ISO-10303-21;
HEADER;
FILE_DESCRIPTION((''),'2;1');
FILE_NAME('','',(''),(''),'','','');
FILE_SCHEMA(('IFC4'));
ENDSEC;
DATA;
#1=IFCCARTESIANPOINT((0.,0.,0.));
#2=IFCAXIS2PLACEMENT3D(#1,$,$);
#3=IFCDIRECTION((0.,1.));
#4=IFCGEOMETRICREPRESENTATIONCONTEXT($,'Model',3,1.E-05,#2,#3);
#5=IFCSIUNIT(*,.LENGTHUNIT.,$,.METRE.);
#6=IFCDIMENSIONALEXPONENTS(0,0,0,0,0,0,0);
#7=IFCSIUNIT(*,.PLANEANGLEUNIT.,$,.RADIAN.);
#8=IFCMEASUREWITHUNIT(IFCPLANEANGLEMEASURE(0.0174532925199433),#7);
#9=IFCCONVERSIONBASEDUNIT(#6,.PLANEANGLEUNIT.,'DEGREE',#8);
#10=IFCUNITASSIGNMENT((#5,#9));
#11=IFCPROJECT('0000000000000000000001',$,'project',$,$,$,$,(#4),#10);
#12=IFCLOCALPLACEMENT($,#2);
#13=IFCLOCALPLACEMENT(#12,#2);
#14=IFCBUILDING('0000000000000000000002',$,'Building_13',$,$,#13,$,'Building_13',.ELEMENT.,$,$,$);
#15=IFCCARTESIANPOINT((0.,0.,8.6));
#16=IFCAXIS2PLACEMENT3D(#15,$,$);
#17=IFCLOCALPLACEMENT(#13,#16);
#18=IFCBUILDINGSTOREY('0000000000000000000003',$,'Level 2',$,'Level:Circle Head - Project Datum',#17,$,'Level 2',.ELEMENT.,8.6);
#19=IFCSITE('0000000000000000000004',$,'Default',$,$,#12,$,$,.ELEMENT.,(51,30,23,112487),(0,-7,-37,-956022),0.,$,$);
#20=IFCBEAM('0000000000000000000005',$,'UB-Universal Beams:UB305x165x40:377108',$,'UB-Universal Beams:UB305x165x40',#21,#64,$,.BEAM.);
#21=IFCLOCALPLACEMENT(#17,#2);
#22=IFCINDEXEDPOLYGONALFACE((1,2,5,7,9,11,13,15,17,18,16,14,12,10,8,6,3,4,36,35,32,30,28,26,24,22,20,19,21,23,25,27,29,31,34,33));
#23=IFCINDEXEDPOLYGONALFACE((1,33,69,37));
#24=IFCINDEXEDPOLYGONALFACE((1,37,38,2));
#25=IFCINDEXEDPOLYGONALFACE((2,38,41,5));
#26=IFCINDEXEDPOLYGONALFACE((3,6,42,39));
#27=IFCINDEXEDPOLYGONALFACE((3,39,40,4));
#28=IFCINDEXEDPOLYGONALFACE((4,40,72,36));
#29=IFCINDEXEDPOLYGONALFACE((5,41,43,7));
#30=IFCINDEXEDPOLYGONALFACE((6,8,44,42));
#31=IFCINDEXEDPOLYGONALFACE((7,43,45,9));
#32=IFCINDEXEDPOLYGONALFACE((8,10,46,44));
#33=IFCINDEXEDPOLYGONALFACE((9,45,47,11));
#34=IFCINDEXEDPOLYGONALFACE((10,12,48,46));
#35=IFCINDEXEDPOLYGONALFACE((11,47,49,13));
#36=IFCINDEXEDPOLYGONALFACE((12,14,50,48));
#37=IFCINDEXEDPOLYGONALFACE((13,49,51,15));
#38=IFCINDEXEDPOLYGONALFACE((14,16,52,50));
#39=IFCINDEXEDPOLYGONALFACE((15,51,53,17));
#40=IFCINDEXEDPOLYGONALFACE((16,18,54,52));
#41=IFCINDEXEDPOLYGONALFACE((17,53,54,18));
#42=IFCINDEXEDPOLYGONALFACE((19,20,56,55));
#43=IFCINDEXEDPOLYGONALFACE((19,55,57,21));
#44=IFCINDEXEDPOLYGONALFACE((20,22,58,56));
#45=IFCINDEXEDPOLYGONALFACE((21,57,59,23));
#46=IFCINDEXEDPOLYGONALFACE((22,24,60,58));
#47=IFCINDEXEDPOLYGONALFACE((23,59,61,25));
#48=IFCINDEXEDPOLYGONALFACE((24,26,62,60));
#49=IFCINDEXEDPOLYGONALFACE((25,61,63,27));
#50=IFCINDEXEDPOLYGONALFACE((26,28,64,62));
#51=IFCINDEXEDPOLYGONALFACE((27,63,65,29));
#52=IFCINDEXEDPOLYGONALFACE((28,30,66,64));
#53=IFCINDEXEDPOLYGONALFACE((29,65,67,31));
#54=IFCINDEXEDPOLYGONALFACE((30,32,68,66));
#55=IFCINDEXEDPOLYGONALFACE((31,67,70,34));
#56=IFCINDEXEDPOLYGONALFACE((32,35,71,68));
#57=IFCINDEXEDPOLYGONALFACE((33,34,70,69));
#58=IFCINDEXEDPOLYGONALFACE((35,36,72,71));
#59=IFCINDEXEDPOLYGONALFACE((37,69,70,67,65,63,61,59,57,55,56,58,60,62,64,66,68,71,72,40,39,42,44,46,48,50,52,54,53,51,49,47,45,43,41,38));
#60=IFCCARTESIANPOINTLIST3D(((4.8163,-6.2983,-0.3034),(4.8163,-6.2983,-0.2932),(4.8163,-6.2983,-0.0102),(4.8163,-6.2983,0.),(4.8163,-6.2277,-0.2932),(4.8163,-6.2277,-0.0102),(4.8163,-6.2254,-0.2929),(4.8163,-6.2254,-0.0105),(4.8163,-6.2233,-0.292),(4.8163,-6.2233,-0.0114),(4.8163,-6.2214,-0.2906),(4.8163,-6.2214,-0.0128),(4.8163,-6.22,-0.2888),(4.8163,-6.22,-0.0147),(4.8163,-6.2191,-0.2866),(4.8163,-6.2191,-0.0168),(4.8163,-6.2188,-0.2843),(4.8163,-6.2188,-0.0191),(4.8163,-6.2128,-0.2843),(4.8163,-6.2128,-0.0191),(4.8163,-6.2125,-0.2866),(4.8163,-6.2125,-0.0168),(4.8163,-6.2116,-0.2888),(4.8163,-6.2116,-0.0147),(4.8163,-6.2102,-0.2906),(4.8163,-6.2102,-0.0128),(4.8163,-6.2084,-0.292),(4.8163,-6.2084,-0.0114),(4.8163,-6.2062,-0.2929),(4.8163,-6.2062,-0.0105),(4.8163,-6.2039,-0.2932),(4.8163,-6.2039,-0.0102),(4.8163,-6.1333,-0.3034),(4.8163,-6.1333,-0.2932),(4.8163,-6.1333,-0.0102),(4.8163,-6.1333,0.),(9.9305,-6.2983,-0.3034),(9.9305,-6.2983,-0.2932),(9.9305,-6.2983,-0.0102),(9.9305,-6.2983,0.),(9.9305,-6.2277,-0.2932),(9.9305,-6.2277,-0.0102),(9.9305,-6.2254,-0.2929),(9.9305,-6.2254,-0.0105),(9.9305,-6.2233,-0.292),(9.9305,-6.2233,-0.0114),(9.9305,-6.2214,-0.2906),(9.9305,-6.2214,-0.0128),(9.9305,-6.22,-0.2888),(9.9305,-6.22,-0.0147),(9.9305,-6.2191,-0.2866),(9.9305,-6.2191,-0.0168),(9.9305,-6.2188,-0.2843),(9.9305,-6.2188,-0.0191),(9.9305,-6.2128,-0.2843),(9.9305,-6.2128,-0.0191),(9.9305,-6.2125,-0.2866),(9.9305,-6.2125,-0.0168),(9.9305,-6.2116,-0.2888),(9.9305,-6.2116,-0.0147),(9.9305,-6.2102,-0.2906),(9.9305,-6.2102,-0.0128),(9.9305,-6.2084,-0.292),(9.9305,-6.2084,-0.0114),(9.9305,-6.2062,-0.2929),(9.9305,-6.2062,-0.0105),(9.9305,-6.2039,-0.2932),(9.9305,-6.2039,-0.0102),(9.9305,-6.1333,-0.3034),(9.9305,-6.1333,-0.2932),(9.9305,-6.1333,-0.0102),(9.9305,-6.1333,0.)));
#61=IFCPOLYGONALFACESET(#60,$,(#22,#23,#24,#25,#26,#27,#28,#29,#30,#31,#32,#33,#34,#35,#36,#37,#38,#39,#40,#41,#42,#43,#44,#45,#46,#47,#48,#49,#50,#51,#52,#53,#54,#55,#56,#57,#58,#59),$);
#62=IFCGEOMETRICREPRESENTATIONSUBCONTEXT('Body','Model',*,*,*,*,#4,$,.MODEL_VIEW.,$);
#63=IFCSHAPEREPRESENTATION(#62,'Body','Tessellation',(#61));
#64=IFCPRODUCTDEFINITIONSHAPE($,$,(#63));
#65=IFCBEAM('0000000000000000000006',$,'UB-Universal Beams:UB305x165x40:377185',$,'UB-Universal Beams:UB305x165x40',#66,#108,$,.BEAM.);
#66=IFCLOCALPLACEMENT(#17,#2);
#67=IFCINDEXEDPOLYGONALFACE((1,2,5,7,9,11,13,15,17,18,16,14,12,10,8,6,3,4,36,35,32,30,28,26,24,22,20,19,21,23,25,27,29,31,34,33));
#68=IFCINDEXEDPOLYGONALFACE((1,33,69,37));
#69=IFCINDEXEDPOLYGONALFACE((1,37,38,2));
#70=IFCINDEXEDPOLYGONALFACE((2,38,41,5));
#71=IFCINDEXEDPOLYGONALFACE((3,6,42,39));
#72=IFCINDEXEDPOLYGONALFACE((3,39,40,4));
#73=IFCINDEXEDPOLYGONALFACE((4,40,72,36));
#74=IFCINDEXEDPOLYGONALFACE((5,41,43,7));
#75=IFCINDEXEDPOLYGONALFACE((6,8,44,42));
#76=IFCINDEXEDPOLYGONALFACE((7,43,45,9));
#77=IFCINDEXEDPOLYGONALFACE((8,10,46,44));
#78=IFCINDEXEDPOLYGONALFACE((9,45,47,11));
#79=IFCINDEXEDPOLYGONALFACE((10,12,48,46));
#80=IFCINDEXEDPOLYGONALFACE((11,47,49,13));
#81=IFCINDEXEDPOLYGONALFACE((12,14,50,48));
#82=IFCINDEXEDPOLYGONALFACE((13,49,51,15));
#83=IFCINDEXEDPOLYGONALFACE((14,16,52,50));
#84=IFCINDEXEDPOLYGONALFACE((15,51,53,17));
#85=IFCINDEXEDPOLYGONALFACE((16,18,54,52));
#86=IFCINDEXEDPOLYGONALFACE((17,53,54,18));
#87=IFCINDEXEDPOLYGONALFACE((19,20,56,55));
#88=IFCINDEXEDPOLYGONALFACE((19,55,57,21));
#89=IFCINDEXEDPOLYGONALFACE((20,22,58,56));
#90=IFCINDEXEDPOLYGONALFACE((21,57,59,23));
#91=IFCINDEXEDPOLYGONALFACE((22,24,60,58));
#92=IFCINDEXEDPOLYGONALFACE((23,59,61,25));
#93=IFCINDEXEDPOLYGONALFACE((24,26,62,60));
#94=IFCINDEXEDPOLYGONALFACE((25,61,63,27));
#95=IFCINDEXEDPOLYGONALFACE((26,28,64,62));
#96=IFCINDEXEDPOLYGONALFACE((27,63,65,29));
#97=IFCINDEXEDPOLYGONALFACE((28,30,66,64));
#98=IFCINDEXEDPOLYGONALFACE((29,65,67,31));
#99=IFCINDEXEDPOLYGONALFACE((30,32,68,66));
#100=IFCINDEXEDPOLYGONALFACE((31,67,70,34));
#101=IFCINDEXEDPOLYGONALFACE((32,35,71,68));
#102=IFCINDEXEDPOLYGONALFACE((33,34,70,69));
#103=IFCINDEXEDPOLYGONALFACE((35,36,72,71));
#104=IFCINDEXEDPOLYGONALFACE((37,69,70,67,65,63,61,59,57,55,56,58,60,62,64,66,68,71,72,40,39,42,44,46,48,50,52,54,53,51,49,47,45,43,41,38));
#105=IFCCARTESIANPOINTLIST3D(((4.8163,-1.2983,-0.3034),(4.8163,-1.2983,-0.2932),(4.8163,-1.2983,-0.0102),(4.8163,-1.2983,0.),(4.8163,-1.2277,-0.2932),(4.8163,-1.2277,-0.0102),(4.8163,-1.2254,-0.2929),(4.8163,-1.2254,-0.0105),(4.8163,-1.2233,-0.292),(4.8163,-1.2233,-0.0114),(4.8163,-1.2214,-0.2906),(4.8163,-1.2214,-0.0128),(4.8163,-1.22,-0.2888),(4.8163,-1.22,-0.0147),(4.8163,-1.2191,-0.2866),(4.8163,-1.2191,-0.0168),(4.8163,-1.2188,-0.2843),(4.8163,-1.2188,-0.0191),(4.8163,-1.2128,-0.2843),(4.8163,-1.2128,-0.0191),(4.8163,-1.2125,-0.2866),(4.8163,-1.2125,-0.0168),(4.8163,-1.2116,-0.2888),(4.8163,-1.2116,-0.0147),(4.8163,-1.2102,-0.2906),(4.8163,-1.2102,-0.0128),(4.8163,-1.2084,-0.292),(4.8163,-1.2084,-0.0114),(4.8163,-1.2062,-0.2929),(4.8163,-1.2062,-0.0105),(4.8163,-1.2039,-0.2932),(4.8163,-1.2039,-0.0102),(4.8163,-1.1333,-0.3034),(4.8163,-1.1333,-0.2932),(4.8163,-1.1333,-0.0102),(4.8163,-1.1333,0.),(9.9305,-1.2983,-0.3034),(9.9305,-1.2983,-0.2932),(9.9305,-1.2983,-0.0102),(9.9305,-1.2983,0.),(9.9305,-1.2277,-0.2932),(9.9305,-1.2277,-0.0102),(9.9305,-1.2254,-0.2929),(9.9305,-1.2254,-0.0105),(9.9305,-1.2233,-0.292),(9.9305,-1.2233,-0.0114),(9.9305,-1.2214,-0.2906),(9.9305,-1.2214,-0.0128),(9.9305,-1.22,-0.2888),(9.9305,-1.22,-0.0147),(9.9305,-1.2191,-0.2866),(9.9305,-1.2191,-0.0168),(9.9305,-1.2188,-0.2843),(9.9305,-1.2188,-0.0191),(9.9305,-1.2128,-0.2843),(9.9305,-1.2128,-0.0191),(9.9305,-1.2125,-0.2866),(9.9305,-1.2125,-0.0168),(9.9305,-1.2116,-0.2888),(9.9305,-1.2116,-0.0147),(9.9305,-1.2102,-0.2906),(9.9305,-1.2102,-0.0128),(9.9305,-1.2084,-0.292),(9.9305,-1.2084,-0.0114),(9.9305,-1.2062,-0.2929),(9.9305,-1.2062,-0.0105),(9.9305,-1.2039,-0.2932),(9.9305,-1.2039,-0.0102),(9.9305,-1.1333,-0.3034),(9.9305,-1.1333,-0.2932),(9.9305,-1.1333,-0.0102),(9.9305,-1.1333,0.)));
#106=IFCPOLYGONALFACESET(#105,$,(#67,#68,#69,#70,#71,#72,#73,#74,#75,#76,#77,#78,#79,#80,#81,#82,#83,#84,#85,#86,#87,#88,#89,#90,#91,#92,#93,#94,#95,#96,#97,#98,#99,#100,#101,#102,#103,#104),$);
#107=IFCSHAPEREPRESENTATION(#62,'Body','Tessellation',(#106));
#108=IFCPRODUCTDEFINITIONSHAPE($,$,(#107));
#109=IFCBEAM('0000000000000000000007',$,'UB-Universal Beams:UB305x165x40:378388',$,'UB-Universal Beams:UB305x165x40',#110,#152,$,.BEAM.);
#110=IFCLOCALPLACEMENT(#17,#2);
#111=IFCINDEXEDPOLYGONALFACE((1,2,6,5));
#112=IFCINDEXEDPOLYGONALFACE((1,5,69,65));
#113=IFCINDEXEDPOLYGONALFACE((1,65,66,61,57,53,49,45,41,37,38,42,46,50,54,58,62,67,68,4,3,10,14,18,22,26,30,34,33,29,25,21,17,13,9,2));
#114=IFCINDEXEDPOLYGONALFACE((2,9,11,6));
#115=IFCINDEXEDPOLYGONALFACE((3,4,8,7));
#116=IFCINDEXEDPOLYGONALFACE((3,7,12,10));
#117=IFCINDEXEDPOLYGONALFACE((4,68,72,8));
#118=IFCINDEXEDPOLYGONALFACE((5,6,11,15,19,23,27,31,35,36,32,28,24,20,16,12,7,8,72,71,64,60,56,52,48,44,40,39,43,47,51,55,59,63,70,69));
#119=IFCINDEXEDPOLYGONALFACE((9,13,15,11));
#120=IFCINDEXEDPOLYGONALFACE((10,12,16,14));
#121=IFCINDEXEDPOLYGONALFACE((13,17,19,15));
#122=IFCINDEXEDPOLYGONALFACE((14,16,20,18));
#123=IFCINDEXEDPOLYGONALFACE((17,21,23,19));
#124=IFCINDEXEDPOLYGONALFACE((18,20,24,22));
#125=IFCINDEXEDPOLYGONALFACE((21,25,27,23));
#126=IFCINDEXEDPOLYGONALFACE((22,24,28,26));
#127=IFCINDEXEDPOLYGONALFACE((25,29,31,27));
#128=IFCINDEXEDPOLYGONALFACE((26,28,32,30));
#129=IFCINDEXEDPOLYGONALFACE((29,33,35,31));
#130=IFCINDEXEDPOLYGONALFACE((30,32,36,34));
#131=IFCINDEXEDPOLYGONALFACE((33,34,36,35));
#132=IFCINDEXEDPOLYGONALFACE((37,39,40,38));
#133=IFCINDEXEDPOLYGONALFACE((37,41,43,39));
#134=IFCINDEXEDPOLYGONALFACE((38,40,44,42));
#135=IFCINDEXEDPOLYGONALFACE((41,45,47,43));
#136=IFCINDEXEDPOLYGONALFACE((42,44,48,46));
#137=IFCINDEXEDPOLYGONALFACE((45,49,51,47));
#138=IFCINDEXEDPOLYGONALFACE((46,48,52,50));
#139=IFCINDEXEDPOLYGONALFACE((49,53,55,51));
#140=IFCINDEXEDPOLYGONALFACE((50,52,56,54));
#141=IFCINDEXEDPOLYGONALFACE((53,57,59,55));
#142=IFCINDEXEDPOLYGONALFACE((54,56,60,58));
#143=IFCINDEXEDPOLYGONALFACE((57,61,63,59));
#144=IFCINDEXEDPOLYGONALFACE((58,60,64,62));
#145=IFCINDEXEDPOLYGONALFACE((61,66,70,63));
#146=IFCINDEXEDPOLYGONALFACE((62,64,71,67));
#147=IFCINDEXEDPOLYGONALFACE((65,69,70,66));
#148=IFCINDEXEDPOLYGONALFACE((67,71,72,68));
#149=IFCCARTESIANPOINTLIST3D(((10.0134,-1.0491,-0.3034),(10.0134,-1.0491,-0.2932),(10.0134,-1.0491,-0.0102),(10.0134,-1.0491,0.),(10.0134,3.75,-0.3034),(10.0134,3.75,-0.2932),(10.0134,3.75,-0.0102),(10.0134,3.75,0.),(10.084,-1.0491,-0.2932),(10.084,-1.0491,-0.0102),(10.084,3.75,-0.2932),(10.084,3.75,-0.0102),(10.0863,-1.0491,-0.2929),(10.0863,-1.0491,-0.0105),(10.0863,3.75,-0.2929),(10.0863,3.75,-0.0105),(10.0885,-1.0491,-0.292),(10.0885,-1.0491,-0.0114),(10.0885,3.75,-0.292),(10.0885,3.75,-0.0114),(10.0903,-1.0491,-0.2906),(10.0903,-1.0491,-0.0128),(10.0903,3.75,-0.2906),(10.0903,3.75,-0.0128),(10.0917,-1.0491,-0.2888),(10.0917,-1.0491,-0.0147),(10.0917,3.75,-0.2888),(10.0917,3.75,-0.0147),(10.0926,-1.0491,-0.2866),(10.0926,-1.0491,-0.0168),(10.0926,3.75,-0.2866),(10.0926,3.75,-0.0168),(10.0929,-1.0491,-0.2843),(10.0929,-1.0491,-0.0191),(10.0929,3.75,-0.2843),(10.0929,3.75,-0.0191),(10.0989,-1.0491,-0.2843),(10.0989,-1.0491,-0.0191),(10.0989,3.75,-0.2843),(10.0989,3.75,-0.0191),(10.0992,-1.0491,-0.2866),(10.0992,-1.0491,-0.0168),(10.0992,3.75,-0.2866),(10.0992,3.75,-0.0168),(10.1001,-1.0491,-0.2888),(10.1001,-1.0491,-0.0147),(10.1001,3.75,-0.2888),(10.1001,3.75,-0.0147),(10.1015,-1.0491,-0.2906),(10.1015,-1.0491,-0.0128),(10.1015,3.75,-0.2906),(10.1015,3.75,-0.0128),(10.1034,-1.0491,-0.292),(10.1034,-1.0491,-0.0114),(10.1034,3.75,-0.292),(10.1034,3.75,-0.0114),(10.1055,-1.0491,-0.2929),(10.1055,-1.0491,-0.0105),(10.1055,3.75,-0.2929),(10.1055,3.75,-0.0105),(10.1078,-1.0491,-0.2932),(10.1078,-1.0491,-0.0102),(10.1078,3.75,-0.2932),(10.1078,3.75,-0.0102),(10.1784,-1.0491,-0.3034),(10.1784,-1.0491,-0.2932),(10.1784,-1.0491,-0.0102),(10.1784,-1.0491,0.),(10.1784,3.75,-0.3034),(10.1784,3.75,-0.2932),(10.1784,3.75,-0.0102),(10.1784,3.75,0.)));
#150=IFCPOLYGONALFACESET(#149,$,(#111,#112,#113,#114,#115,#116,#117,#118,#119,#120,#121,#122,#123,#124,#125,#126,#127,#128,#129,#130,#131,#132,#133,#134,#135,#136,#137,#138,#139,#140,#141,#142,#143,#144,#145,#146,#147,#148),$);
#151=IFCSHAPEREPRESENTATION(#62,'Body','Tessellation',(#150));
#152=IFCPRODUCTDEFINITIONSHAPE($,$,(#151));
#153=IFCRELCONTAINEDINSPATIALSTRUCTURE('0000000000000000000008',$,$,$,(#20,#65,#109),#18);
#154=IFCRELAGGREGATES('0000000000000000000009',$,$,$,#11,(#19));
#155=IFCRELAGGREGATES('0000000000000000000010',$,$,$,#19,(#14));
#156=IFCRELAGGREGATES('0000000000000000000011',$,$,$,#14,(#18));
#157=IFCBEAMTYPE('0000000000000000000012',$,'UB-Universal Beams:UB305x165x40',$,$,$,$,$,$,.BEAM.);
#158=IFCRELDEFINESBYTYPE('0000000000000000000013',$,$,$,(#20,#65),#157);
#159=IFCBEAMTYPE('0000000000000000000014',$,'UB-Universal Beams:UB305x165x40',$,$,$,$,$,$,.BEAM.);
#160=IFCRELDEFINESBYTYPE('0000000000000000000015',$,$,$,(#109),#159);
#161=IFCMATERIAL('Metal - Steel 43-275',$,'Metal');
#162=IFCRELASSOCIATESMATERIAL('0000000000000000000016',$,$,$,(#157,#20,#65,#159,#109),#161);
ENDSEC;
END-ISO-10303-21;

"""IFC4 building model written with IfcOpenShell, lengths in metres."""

from ifc_helpers import new_model, entity, si_unit, converted_unit, direction, frame, origin, place, context, subcontext, project, spatial, line, arc, indexed_curve, outline, extrude, source, transform, mapped, material, type_object, type_shapes, element, save


model = new_model("IFC4")

# Units and contexts
model_context = context("Model", 3, precision=1e-05, world=origin(), true_north=direction((0.0, 1.0)))
body_context = subcontext(model_context, "Body", "Model", "MODEL_VIEW")
ifc_project = project(units=[si_unit("LENGTHUNIT", "METRE"), converted_unit("PLANEANGLEUNIT", "DEGREE", entity("IfcPlaneAngleMeasure", 0.0174532925199433), si_unit("PLANEANGLEUNIT", "RADIAN"), dimensions=[0, 0, 0, 0, 0, 0, 0])], contexts=[model_context])

# Site, building, storey
site_placement = place(None, origin())
site = spatial("IfcSite", under=ifc_project, at=site_placement, Name="Default", CompositionType="ELEMENT", RefLatitude=(51, 30, 23, 112487), RefLongitude=(0, -7, -37, -956022), RefElevation=0.0)
building_placement = place(site_placement, origin())
building = spatial("IfcBuilding", under=site, at=building_placement, Name="Building_13", LongName="Building_13", CompositionType="ELEMENT")
storey_placement = place(building_placement, frame((0.0, 0.0, 8.6)))
storey = spatial("IfcBuildingStorey", under=building, at=storey_placement, Name="Level 2", ObjectType="Level:Circle Head - Project Datum", LongName="Level 2", CompositionType="ELEMENT", Elevation=8.6)

# Beams
ifc_material_1 = material(Name="Metal - Steel 43-275", Category="Metal")
beam_type_1 = type_object("IfcBeamType", Name="UB-Universal Beams:UB305x165x40", PredefinedType="BEAM", material=ifc_material_1)
shared_shape_1 = source(origin(), body_context, "Body", "SweptSolid", [
    extrude(outline(indexed_curve([(-0.0825, -0.1415), (-0.0825, -0.1517), (0.0825, -0.1517), (0.0825, -0.1415), (0.0119, -0.1415), (0.0056, -0.1389), (0.003, -0.1326), (0.003, 0.1326), (0.0056, 0.1389), (0.0119, 0.1415), (0.0825, 0.1415), (0.0825, 0.1517), (-0.0825, 0.1517), (-0.0825, 0.1415), (-0.0119, 0.1415), (-0.0056, 0.1389), (-0.003, 0.1326), (-0.003, -0.1326), (-0.0056, -0.1389), (-0.0119, -0.1415)], segments=[line(1, 2, 3, 4, 5), arc(5, 6, 7), line(7, 8), arc(8, 9, 10), line(10, 11, 12, 13, 14, 15), arc(15, 16, 17), line(17, 18), arc(18, 19, 20), line(20, 1)], self_intersect=False)), frame((-2.5571, 0.0, 0.0), z_axis=(-1.0, 0.0, 0.0), x_axis=(0.0, -1.0, 0.0)), (0.0, 0.0, -1.0), 5.1142),
])
type_shapes(beam_type_1, [shared_shape_1])
beam_1_placement = place(storey_placement, frame((7.3734, -6.2158, -0.1517)))
element("IfcBeam", 1, at=beam_1_placement, inside=storey, type_object=beam_type_1, material=ifc_material_1, Name="UB-Universal Beams:UB305x165x40:377108", ObjectType="UB-Universal Beams:UB305x165x40", PredefinedType="BEAM", context=body_context, shape_type="MappedRepresentation", body=[
    mapped(shared_shape_1, transform((0.0, 0.0, 0.0), scale=1.0)),
])
beam_2_placement = place(storey_placement, frame((7.3734, -1.2158, -0.1517), z_axis=(0.0, 0.0, 1.0), x_axis=(-1.0, 0.0, 0.0)))
element("IfcBeam", 2, at=beam_2_placement, inside=storey, type_object=beam_type_1, material=ifc_material_1, Name="UB-Universal Beams:UB305x165x40:377185", ObjectType="UB-Universal Beams:UB305x165x40", PredefinedType="BEAM", context=body_context, shape_type="MappedRepresentation", body=[
    mapped(shared_shape_1, transform((0.0, 0.0, 0.0), scale=1.0)),
])
beam_type_2 = type_object("IfcBeamType", Name="UB-Universal Beams:UB305x165x40", PredefinedType="BEAM", material=ifc_material_1)
shared_shape_2 = source(origin(), body_context, "Body", "SweptSolid", [
    extrude(outline(indexed_curve([(-0.0825, -0.1415), (-0.0825, -0.1517), (0.0825, -0.1517), (0.0825, -0.1415), (0.0119, -0.1415), (0.0056, -0.1389), (0.003, -0.1326), (0.003, 0.1326), (0.0056, 0.1389), (0.0119, 0.1415), (0.0825, 0.1415), (0.0825, 0.1517), (-0.0825, 0.1517), (-0.0825, 0.1415), (-0.0119, 0.1415), (-0.0056, 0.1389), (-0.003, 0.1326), (-0.003, -0.1326), (-0.0056, -0.1389), (-0.0119, -0.1415)], segments=[line(1, 2, 3, 4, 5), arc(5, 6, 7), line(7, 8), arc(8, 9, 10), line(10, 11, 12, 13, 14, 15), arc(15, 16, 17), line(17, 18), arc(18, 19, 20), line(20, 1)], self_intersect=False)), frame((-2.3996, 0.0, 0.0), z_axis=(-1.0, 0.0, 0.0), x_axis=(0.0, -1.0, 0.0)), (0.0, 0.0, -1.0), 4.7991),
])
type_shapes(beam_type_2, [shared_shape_2])
for number, where, z_axis, x_axis, name in (
    (3, (10.0959, 1.3504, -0.1517), (0.0, 0.0, 1.0), (0.0, 1.0, 0.0), "UB-Universal Beams:UB305x165x40:378388"),
):
    element("IfcBeam", number, at=place(storey_placement, frame(where, z_axis=z_axis, x_axis=x_axis)), inside=storey, type_object=beam_type_2, material=ifc_material_1, Name=name, ObjectType="UB-Universal Beams:UB305x165x40", PredefinedType="BEAM", context=body_context, shape_type="MappedRepresentation", body=[
        mapped(shared_shape_2, transform((0.0, 0.0, 0.0), scale=1.0)),
    ])

save(model, "model.ifc")
